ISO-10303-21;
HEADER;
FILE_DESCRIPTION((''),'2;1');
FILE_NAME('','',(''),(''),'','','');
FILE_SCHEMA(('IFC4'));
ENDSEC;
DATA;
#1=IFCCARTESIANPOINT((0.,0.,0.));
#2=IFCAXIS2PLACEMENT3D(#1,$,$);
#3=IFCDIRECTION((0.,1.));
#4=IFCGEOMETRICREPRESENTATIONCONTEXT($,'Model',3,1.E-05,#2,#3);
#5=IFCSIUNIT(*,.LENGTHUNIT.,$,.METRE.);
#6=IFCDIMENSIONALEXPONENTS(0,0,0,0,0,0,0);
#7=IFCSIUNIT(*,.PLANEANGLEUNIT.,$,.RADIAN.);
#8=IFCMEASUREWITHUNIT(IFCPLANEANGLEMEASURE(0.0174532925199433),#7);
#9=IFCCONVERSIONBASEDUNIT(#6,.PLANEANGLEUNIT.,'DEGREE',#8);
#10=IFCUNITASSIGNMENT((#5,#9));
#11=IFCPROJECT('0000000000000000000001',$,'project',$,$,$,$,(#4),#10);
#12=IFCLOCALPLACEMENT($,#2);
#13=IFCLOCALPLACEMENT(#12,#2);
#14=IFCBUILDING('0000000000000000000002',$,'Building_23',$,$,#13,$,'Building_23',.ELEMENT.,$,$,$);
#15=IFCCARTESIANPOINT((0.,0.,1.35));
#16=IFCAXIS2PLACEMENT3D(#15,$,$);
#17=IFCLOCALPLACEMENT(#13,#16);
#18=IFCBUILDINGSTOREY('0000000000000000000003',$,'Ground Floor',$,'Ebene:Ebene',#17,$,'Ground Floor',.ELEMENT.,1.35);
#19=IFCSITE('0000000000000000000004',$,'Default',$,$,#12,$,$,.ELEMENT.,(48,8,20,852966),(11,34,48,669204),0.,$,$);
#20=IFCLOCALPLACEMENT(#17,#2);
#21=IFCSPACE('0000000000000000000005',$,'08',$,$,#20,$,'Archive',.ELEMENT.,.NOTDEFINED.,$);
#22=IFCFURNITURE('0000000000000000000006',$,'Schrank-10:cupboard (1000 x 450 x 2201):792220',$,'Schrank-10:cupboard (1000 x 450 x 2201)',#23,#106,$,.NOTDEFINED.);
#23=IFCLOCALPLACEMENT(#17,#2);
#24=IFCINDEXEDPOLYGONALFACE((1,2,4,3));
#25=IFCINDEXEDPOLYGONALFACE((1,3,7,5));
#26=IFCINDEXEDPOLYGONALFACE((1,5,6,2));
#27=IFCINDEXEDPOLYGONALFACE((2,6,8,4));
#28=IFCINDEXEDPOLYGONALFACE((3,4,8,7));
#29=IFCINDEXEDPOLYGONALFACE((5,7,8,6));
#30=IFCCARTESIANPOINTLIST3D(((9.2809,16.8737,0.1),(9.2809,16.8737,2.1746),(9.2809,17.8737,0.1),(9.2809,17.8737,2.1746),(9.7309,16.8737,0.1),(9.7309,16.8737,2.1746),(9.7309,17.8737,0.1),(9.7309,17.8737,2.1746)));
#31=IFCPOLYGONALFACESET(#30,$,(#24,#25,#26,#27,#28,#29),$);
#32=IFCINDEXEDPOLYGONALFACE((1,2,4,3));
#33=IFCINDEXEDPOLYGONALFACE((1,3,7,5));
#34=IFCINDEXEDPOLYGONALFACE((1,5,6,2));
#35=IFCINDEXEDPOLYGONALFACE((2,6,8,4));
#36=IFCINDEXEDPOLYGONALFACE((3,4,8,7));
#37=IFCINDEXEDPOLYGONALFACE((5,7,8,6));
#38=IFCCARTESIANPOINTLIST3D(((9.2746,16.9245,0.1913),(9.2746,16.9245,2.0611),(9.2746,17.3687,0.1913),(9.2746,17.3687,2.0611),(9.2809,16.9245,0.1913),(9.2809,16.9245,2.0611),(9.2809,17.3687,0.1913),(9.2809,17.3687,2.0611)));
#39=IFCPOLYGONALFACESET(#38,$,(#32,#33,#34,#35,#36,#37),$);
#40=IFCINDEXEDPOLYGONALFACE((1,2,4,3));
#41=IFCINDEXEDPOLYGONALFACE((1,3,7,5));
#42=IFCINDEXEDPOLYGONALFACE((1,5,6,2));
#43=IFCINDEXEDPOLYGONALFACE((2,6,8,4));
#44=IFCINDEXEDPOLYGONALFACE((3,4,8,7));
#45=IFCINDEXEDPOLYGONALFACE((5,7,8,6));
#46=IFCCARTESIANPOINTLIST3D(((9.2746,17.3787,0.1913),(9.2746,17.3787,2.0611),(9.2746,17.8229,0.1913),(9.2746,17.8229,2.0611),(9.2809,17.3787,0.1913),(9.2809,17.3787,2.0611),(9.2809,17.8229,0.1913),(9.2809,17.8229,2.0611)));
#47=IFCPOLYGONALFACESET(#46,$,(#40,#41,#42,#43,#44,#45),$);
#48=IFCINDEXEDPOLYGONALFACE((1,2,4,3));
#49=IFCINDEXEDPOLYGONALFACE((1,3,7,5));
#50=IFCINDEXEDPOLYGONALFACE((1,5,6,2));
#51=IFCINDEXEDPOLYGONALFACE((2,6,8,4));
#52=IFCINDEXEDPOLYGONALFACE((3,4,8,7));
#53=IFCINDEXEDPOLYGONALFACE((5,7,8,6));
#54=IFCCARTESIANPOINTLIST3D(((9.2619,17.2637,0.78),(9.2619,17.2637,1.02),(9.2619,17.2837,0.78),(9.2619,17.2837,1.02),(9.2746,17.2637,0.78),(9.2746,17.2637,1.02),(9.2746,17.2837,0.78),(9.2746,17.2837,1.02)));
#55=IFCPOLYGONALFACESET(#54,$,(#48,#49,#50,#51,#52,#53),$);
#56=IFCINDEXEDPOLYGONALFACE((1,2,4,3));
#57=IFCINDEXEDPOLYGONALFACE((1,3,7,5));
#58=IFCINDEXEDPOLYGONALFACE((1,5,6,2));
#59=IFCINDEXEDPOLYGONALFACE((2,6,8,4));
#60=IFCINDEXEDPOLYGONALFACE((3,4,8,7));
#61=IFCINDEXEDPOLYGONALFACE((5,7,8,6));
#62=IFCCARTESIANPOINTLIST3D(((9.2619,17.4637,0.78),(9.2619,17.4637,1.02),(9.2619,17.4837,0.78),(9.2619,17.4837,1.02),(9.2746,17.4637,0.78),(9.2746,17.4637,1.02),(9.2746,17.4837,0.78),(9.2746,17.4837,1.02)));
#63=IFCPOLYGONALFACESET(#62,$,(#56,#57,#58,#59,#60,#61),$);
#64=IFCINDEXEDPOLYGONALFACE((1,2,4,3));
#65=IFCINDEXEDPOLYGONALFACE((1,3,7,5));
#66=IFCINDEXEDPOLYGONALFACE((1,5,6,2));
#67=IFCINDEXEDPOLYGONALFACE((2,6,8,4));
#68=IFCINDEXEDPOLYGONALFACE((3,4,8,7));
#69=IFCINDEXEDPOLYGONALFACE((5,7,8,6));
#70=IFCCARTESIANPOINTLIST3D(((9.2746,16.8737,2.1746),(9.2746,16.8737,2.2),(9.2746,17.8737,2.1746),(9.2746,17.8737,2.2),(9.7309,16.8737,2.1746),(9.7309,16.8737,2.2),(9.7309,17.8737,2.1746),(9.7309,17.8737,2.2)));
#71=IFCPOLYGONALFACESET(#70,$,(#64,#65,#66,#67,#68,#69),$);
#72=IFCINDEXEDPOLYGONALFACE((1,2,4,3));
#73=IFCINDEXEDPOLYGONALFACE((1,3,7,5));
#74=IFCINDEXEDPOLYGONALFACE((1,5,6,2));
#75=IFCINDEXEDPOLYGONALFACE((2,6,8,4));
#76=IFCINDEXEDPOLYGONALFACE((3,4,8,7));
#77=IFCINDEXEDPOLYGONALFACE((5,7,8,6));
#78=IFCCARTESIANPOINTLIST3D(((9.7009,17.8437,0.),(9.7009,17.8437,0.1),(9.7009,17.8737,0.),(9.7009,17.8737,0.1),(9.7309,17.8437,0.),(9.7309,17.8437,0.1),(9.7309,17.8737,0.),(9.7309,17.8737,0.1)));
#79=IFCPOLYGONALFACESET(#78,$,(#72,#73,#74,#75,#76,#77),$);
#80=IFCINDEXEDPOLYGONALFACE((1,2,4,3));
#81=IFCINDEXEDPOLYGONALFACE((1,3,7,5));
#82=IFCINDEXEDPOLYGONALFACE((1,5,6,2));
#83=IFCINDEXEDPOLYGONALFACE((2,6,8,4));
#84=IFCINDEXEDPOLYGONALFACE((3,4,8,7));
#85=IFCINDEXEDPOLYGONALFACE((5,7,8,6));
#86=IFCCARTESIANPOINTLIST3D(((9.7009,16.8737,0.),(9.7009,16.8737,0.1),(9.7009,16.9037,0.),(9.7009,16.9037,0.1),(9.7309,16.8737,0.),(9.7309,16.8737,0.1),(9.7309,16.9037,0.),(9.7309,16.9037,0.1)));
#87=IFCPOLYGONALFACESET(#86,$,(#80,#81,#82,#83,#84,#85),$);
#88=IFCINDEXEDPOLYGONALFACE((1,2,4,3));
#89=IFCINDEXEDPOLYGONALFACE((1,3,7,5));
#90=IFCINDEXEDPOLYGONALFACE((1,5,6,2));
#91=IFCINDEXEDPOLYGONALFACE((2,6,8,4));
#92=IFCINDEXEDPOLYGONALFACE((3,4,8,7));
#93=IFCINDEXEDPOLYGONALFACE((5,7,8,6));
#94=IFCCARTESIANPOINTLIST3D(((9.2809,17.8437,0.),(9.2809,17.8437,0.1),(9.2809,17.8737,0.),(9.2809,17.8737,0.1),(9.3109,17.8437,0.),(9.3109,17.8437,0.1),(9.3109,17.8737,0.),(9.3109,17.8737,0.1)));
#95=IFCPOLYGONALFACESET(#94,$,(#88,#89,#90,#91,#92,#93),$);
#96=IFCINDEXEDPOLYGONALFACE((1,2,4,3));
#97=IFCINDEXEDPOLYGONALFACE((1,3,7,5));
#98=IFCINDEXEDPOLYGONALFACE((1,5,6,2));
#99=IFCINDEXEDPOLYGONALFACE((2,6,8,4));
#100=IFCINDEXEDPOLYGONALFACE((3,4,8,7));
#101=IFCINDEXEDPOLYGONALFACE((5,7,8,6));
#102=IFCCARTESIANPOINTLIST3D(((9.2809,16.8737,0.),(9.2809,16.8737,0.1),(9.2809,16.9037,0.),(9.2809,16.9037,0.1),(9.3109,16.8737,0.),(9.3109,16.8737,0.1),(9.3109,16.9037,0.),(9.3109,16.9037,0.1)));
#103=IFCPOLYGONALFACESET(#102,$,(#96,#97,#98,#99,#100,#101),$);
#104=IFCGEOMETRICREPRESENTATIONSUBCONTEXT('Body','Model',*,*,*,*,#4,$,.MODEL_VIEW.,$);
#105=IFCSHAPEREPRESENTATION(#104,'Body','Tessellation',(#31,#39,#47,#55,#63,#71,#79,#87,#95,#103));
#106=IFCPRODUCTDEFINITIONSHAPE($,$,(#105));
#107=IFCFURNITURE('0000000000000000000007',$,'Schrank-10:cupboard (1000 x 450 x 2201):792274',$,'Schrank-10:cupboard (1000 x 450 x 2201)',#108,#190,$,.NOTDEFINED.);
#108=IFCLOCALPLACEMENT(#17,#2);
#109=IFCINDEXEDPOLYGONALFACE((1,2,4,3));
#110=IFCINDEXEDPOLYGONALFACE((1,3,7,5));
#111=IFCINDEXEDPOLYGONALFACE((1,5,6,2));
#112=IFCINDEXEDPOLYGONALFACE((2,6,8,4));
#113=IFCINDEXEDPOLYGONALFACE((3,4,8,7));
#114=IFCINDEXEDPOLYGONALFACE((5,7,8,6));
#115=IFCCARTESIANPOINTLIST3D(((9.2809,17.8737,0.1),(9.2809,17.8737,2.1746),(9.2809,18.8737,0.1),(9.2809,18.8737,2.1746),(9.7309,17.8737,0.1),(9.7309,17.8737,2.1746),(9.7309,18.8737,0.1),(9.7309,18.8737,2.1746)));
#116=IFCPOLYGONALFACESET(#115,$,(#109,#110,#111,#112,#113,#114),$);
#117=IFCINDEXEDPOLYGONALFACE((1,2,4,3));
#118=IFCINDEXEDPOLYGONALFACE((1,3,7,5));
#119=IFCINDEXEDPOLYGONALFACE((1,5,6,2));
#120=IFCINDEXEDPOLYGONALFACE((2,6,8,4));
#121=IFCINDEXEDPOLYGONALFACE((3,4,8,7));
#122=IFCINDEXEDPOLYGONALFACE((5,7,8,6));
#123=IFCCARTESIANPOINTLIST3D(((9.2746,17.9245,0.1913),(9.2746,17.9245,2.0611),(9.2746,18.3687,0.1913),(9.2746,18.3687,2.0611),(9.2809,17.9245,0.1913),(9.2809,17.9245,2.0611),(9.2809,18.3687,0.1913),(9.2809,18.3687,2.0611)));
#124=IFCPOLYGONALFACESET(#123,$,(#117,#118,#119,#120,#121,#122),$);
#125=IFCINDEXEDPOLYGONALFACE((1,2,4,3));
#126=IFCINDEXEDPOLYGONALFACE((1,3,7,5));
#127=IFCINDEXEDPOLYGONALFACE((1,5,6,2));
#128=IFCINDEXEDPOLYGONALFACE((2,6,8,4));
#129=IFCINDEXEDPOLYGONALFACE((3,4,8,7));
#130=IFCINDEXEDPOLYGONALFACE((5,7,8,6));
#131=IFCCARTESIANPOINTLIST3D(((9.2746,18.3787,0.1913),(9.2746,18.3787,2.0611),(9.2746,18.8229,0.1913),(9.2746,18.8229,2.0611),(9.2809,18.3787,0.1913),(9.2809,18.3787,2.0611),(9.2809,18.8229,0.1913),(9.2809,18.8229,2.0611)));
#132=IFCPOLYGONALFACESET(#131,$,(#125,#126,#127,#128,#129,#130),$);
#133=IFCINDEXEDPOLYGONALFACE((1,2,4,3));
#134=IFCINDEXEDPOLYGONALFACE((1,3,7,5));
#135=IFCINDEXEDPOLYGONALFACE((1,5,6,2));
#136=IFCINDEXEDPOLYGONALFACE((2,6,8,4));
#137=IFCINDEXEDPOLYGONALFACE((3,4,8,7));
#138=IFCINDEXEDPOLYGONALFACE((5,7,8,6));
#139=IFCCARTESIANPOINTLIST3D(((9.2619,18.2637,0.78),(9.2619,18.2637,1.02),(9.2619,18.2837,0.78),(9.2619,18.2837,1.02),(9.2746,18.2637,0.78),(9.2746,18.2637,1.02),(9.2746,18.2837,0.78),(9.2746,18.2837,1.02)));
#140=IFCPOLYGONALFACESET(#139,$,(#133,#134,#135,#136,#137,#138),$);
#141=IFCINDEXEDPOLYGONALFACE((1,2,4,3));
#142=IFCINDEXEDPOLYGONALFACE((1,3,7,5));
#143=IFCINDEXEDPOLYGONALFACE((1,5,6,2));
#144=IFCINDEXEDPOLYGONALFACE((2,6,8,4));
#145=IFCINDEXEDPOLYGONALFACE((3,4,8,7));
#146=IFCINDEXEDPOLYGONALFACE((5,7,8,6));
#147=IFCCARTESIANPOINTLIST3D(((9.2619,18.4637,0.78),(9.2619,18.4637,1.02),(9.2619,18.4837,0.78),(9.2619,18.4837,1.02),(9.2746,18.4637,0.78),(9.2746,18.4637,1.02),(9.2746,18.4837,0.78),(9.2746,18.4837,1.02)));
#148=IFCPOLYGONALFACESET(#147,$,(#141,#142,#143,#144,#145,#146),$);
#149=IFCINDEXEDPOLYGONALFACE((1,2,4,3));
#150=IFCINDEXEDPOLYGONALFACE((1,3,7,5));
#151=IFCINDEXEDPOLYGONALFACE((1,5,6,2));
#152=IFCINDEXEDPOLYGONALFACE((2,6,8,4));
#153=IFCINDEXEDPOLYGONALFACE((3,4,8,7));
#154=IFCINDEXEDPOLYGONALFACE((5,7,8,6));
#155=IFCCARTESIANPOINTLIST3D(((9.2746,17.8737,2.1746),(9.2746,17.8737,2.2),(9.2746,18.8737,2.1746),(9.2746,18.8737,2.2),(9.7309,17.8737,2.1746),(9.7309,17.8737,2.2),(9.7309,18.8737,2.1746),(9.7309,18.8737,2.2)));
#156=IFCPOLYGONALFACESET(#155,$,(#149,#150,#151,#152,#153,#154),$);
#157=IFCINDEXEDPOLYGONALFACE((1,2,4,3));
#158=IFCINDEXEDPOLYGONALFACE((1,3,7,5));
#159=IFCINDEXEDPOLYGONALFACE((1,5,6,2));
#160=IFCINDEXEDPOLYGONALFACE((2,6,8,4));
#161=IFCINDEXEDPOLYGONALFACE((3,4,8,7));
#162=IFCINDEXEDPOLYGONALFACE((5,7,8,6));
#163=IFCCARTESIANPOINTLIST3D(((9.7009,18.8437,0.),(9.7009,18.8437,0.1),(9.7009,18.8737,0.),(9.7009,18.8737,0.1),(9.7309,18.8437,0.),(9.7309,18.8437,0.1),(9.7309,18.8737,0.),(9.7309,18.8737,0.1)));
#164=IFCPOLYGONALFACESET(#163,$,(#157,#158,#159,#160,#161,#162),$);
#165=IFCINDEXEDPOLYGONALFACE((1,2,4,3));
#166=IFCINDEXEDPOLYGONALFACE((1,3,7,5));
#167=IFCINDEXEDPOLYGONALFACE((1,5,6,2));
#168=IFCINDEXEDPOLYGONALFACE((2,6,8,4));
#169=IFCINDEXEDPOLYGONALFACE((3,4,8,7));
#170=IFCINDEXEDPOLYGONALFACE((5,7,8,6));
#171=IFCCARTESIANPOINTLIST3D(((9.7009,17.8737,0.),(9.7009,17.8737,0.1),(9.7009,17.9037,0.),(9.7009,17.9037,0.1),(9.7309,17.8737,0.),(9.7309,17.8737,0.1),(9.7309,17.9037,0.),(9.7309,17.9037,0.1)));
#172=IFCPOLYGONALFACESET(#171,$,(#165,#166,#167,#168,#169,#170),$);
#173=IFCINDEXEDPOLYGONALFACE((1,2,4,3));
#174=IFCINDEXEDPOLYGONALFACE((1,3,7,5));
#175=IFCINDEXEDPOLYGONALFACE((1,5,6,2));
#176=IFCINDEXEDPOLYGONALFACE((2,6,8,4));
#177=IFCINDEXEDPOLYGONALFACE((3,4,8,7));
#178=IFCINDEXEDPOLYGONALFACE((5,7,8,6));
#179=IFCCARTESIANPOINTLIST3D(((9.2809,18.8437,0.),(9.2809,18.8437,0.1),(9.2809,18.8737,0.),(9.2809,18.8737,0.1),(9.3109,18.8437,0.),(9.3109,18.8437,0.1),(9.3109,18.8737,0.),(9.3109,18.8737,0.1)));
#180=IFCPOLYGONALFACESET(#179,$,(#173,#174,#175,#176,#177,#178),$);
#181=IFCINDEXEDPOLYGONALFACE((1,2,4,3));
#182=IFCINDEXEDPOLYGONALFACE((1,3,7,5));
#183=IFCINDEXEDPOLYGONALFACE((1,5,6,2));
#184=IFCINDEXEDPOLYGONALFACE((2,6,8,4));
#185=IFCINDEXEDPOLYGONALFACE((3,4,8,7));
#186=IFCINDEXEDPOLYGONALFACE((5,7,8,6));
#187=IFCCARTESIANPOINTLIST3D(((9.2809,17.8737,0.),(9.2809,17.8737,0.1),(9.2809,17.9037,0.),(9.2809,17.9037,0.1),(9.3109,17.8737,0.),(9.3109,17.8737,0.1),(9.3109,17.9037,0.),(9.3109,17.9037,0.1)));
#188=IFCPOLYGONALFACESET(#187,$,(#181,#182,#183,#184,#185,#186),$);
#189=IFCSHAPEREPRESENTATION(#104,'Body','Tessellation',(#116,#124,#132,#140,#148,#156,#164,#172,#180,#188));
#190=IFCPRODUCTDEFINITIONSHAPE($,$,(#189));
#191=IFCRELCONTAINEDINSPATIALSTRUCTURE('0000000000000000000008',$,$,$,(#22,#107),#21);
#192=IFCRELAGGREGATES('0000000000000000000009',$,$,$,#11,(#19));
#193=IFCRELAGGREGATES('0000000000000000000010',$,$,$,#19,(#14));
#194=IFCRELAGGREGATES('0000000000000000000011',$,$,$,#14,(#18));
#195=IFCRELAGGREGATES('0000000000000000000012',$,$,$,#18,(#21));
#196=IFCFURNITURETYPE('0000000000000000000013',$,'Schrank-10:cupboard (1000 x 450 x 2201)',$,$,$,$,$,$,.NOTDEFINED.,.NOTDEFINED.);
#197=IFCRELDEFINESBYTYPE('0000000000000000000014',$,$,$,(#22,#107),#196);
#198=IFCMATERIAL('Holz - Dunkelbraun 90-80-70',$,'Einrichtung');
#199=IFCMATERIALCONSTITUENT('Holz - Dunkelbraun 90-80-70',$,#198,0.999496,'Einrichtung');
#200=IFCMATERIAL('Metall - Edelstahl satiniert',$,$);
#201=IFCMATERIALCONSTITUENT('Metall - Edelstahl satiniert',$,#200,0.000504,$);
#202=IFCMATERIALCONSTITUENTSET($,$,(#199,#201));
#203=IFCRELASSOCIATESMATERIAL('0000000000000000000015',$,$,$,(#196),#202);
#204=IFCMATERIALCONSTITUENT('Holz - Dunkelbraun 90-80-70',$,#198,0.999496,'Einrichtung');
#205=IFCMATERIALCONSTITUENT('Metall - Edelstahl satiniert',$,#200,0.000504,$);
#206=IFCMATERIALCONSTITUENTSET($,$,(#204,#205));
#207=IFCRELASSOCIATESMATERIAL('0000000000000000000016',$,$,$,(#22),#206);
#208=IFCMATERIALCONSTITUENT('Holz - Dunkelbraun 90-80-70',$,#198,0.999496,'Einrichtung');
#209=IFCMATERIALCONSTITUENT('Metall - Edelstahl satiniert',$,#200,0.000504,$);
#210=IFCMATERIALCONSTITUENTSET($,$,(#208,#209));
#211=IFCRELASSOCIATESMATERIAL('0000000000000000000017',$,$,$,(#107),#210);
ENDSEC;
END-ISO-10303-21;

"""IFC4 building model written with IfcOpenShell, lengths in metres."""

from ifc_helpers import new_model, entity, si_unit, converted_unit, direction, frame, origin, place, context, subcontext, project, spatial, indexed_curve, outline, extrude, source, transform, mapped, material, constituent, constituent_set, type_object, type_shapes, element, save


model = new_model("IFC4")

# Units and contexts
model_context = context("Model", 3, precision=1e-05, world=origin(), true_north=direction((0.0, 1.0)))
body_context = subcontext(model_context, "Body", "Model", "MODEL_VIEW")
ifc_project = project(units=[si_unit("LENGTHUNIT", "METRE"), converted_unit("PLANEANGLEUNIT", "DEGREE", entity("IfcPlaneAngleMeasure", 0.0174532925199433), si_unit("PLANEANGLEUNIT", "RADIAN"), dimensions=[0, 0, 0, 0, 0, 0, 0])], contexts=[model_context])

# Site, building, storey
site_placement = place(None, origin())
site = spatial("IfcSite", under=ifc_project, at=site_placement, Name="Default", CompositionType="ELEMENT", RefLatitude=(48, 8, 20, 852966), RefLongitude=(11, 34, 48, 669204), RefElevation=0.0)
building_placement = place(site_placement, origin())
building = spatial("IfcBuilding", under=site, at=building_placement, Name="Building_23", LongName="Building_23", CompositionType="ELEMENT")
storey_placement = place(building_placement, frame((0.0, 0.0, 1.35)))
storey = spatial("IfcBuildingStorey", under=building, at=storey_placement, Name="Ground Floor", ObjectType="Ebene:Ebene", LongName="Ground Floor", CompositionType="ELEMENT", Elevation=1.35)

# Shared definitions
space_placement = place(storey_placement, origin())
space = spatial("IfcSpace", under=storey, at=space_placement, Name="08", LongName="Archive", CompositionType="ELEMENT", PredefinedType="NOTDEFINED")

# Furniture
ifc_material_1 = material(Name="Holz - Dunkelbraun 90-80-70", Category="Einrichtung")
ifc_material_2 = material(Name="Metall - Edelstahl satiniert")
ifc_constituent_1 = constituent(ifc_material_1, Name="Holz - Dunkelbraun 90-80-70", Category="Einrichtung", fraction=0.999496)
ifc_constituent_2 = constituent(ifc_material_2, Name="Metall - Edelstahl satiniert", fraction=0.000504)
ifc_constituent_set_1 = constituent_set(constituents=[ifc_constituent_1, ifc_constituent_2])
furniture_type = type_object("IfcFurnitureType", Name="Schrank-10:cupboard (1000 x 450 x 2201)", AssemblyPlace="NOTDEFINED", PredefinedType="NOTDEFINED", material=ifc_constituent_set_1)
shared_shape_1 = source(origin(), body_context, "Body", "SweptSolid", [
    extrude(outline(indexed_curve([(-0.225, -0.5), (0.225, -0.5), (0.225, 0.5), (-0.225, 0.5), (-0.225, -0.5)], self_intersect=False)), frame((-0.2692, -0.3632, 0.1), z_axis=(0.0, 0.0, 1.0), x_axis=(0.0, 1.0, 0.0)), (0.0, 0.0, 1.0), 2.0746),
    extrude(outline(indexed_curve([(-0.0032, -0.2221), (0.0032, -0.2221), (0.0032, 0.2221), (-0.0032, 0.2221), (-0.0032, -0.2221)], self_intersect=False)), frame((-0.0421, -0.5913, 0.1913), z_axis=(0.0, 0.0, 1.0), x_axis=(0.0, 1.0, 0.0)), (0.0, 0.0, 1.0), 1.8698),
    extrude(outline(indexed_curve([(-0.0032, -0.2221), (0.0032, -0.2221), (0.0032, 0.2221), (-0.0032, 0.2221), (-0.0032, -0.2221)], self_intersect=False)), frame((-0.4963, -0.5913, 0.1913), z_axis=(0.0, 0.0, 1.0), x_axis=(0.0, 1.0, 0.0)), (0.0, 0.0, 1.0), 1.8698),
    extrude(outline(indexed_curve([(-0.0063, -0.01), (0.0063, -0.01), (0.0063, 0.01), (-0.0063, 0.01), (-0.0063, -0.01)], self_intersect=False)), frame((-0.1692, -0.6009, 0.78), z_axis=(0.0, 0.0, 1.0), x_axis=(0.0, 1.0, 0.0)), (0.0, 0.0, 1.0), 0.24),
    extrude(outline(indexed_curve([(-0.0063, -0.01), (0.0063, -0.01), (0.0063, 0.01), (-0.0063, 0.01), (-0.0063, -0.01)], self_intersect=False)), frame((-0.3692, -0.6009, 0.78), z_axis=(0.0, 0.0, 1.0), x_axis=(0.0, 1.0, 0.0)), (0.0, 0.0, 1.0), 0.24),
    extrude(outline(indexed_curve([(-0.5, -0.2282), (0.5, -0.2282), (0.5, 0.2282), (-0.5, 0.2282), (-0.5, -0.2282)], self_intersect=False)), frame((-0.2692, -0.3663, 2.1746), z_axis=(0.0, 0.0, 1.0), x_axis=(-1.0, 0.0, 0.0)), (0.0, 0.0, 1.0), 0.0254),
    extrude(outline(indexed_curve([(-0.015, -0.015), (0.015, -0.015), (0.015, 0.015), (-0.015, 0.015), (-0.015, -0.015)], self_intersect=False)), frame((-0.7542, -0.1532, 0.0), z_axis=(0.0, 0.0, 1.0), x_axis=(-1.0, 0.0, 0.0)), (0.0, 0.0, 1.0), 0.1),
    extrude(outline(indexed_curve([(-0.015, -0.015), (0.015, -0.015), (0.015, 0.015), (-0.015, 0.015), (-0.015, -0.015)], self_intersect=False)), frame((0.2158, -0.1532, 0.0), z_axis=(0.0, 0.0, 1.0), x_axis=(0.0, -1.0, 0.0)), (0.0, 0.0, 1.0), 0.1),
    extrude(outline(indexed_curve([(-0.015, -0.015), (0.015, -0.015), (0.015, 0.015), (-0.015, 0.015), (-0.015, -0.015)], self_intersect=False)), frame((-0.7542, -0.5732, 0.0), z_axis=(0.0, 0.0, 1.0), x_axis=(0.0, 1.0, 0.0)), (0.0, 0.0, 1.0), 0.1),
    extrude(outline(indexed_curve([(-0.015, -0.015), (0.015, -0.015), (0.015, 0.015), (-0.015, 0.015), (-0.015, -0.015)], self_intersect=False)), frame((0.2158, -0.5732, 0.0)), (0.0, 0.0, 1.0), 0.1),
])
type_shapes(furniture_type, [shared_shape_1])
ifc_constituent_3 = constituent(ifc_material_1, Name="Holz - Dunkelbraun 90-80-70", Category="Einrichtung", fraction=0.999496)
ifc_constituent_4 = constituent(ifc_material_2, Name="Metall - Edelstahl satiniert", fraction=0.000504)
ifc_constituent_set_2 = constituent_set(constituents=[ifc_constituent_3, ifc_constituent_4])
furniture_1_placement = place(space_placement, frame((9.8691, 17.1045, 0.0), z_axis=(0.0, 0.0, 1.0), x_axis=(0.0, -1.0, 0.0)))
element("IfcFurniture", 1, at=furniture_1_placement, inside=space, type_object=furniture_type, material=ifc_constituent_set_2, Name="Schrank-10:cupboard (1000 x 450 x 2201):792220", ObjectType="Schrank-10:cupboard (1000 x 450 x 2201)", PredefinedType="NOTDEFINED", context=body_context, shape_type="MappedRepresentation", body=[
    mapped(shared_shape_1, transform((0.0, 0.0, 0.0), scale=1.0)),
])
ifc_constituent_5 = constituent(ifc_material_1, Name="Holz - Dunkelbraun 90-80-70", Category="Einrichtung", fraction=0.999496)
ifc_constituent_6 = constituent(ifc_material_2, Name="Metall - Edelstahl satiniert", fraction=0.000504)
ifc_constituent_set_3 = constituent_set(constituents=[ifc_constituent_5, ifc_constituent_6])
furniture_2_placement = place(space_placement, frame((9.8691, 18.1045, 0.0), z_axis=(0.0, 0.0, 1.0), x_axis=(0.0, -1.0, 0.0)))
element("IfcFurniture", 2, at=furniture_2_placement, inside=space, type_object=furniture_type, material=ifc_constituent_set_3, Name="Schrank-10:cupboard (1000 x 450 x 2201):792274", ObjectType="Schrank-10:cupboard (1000 x 450 x 2201)", PredefinedType="NOTDEFINED", context=body_context, shape_type="MappedRepresentation", body=[
    mapped(shared_shape_1, transform((0.0, 0.0, 0.0), scale=1.0)),
])

save(model, "model.ifc")
